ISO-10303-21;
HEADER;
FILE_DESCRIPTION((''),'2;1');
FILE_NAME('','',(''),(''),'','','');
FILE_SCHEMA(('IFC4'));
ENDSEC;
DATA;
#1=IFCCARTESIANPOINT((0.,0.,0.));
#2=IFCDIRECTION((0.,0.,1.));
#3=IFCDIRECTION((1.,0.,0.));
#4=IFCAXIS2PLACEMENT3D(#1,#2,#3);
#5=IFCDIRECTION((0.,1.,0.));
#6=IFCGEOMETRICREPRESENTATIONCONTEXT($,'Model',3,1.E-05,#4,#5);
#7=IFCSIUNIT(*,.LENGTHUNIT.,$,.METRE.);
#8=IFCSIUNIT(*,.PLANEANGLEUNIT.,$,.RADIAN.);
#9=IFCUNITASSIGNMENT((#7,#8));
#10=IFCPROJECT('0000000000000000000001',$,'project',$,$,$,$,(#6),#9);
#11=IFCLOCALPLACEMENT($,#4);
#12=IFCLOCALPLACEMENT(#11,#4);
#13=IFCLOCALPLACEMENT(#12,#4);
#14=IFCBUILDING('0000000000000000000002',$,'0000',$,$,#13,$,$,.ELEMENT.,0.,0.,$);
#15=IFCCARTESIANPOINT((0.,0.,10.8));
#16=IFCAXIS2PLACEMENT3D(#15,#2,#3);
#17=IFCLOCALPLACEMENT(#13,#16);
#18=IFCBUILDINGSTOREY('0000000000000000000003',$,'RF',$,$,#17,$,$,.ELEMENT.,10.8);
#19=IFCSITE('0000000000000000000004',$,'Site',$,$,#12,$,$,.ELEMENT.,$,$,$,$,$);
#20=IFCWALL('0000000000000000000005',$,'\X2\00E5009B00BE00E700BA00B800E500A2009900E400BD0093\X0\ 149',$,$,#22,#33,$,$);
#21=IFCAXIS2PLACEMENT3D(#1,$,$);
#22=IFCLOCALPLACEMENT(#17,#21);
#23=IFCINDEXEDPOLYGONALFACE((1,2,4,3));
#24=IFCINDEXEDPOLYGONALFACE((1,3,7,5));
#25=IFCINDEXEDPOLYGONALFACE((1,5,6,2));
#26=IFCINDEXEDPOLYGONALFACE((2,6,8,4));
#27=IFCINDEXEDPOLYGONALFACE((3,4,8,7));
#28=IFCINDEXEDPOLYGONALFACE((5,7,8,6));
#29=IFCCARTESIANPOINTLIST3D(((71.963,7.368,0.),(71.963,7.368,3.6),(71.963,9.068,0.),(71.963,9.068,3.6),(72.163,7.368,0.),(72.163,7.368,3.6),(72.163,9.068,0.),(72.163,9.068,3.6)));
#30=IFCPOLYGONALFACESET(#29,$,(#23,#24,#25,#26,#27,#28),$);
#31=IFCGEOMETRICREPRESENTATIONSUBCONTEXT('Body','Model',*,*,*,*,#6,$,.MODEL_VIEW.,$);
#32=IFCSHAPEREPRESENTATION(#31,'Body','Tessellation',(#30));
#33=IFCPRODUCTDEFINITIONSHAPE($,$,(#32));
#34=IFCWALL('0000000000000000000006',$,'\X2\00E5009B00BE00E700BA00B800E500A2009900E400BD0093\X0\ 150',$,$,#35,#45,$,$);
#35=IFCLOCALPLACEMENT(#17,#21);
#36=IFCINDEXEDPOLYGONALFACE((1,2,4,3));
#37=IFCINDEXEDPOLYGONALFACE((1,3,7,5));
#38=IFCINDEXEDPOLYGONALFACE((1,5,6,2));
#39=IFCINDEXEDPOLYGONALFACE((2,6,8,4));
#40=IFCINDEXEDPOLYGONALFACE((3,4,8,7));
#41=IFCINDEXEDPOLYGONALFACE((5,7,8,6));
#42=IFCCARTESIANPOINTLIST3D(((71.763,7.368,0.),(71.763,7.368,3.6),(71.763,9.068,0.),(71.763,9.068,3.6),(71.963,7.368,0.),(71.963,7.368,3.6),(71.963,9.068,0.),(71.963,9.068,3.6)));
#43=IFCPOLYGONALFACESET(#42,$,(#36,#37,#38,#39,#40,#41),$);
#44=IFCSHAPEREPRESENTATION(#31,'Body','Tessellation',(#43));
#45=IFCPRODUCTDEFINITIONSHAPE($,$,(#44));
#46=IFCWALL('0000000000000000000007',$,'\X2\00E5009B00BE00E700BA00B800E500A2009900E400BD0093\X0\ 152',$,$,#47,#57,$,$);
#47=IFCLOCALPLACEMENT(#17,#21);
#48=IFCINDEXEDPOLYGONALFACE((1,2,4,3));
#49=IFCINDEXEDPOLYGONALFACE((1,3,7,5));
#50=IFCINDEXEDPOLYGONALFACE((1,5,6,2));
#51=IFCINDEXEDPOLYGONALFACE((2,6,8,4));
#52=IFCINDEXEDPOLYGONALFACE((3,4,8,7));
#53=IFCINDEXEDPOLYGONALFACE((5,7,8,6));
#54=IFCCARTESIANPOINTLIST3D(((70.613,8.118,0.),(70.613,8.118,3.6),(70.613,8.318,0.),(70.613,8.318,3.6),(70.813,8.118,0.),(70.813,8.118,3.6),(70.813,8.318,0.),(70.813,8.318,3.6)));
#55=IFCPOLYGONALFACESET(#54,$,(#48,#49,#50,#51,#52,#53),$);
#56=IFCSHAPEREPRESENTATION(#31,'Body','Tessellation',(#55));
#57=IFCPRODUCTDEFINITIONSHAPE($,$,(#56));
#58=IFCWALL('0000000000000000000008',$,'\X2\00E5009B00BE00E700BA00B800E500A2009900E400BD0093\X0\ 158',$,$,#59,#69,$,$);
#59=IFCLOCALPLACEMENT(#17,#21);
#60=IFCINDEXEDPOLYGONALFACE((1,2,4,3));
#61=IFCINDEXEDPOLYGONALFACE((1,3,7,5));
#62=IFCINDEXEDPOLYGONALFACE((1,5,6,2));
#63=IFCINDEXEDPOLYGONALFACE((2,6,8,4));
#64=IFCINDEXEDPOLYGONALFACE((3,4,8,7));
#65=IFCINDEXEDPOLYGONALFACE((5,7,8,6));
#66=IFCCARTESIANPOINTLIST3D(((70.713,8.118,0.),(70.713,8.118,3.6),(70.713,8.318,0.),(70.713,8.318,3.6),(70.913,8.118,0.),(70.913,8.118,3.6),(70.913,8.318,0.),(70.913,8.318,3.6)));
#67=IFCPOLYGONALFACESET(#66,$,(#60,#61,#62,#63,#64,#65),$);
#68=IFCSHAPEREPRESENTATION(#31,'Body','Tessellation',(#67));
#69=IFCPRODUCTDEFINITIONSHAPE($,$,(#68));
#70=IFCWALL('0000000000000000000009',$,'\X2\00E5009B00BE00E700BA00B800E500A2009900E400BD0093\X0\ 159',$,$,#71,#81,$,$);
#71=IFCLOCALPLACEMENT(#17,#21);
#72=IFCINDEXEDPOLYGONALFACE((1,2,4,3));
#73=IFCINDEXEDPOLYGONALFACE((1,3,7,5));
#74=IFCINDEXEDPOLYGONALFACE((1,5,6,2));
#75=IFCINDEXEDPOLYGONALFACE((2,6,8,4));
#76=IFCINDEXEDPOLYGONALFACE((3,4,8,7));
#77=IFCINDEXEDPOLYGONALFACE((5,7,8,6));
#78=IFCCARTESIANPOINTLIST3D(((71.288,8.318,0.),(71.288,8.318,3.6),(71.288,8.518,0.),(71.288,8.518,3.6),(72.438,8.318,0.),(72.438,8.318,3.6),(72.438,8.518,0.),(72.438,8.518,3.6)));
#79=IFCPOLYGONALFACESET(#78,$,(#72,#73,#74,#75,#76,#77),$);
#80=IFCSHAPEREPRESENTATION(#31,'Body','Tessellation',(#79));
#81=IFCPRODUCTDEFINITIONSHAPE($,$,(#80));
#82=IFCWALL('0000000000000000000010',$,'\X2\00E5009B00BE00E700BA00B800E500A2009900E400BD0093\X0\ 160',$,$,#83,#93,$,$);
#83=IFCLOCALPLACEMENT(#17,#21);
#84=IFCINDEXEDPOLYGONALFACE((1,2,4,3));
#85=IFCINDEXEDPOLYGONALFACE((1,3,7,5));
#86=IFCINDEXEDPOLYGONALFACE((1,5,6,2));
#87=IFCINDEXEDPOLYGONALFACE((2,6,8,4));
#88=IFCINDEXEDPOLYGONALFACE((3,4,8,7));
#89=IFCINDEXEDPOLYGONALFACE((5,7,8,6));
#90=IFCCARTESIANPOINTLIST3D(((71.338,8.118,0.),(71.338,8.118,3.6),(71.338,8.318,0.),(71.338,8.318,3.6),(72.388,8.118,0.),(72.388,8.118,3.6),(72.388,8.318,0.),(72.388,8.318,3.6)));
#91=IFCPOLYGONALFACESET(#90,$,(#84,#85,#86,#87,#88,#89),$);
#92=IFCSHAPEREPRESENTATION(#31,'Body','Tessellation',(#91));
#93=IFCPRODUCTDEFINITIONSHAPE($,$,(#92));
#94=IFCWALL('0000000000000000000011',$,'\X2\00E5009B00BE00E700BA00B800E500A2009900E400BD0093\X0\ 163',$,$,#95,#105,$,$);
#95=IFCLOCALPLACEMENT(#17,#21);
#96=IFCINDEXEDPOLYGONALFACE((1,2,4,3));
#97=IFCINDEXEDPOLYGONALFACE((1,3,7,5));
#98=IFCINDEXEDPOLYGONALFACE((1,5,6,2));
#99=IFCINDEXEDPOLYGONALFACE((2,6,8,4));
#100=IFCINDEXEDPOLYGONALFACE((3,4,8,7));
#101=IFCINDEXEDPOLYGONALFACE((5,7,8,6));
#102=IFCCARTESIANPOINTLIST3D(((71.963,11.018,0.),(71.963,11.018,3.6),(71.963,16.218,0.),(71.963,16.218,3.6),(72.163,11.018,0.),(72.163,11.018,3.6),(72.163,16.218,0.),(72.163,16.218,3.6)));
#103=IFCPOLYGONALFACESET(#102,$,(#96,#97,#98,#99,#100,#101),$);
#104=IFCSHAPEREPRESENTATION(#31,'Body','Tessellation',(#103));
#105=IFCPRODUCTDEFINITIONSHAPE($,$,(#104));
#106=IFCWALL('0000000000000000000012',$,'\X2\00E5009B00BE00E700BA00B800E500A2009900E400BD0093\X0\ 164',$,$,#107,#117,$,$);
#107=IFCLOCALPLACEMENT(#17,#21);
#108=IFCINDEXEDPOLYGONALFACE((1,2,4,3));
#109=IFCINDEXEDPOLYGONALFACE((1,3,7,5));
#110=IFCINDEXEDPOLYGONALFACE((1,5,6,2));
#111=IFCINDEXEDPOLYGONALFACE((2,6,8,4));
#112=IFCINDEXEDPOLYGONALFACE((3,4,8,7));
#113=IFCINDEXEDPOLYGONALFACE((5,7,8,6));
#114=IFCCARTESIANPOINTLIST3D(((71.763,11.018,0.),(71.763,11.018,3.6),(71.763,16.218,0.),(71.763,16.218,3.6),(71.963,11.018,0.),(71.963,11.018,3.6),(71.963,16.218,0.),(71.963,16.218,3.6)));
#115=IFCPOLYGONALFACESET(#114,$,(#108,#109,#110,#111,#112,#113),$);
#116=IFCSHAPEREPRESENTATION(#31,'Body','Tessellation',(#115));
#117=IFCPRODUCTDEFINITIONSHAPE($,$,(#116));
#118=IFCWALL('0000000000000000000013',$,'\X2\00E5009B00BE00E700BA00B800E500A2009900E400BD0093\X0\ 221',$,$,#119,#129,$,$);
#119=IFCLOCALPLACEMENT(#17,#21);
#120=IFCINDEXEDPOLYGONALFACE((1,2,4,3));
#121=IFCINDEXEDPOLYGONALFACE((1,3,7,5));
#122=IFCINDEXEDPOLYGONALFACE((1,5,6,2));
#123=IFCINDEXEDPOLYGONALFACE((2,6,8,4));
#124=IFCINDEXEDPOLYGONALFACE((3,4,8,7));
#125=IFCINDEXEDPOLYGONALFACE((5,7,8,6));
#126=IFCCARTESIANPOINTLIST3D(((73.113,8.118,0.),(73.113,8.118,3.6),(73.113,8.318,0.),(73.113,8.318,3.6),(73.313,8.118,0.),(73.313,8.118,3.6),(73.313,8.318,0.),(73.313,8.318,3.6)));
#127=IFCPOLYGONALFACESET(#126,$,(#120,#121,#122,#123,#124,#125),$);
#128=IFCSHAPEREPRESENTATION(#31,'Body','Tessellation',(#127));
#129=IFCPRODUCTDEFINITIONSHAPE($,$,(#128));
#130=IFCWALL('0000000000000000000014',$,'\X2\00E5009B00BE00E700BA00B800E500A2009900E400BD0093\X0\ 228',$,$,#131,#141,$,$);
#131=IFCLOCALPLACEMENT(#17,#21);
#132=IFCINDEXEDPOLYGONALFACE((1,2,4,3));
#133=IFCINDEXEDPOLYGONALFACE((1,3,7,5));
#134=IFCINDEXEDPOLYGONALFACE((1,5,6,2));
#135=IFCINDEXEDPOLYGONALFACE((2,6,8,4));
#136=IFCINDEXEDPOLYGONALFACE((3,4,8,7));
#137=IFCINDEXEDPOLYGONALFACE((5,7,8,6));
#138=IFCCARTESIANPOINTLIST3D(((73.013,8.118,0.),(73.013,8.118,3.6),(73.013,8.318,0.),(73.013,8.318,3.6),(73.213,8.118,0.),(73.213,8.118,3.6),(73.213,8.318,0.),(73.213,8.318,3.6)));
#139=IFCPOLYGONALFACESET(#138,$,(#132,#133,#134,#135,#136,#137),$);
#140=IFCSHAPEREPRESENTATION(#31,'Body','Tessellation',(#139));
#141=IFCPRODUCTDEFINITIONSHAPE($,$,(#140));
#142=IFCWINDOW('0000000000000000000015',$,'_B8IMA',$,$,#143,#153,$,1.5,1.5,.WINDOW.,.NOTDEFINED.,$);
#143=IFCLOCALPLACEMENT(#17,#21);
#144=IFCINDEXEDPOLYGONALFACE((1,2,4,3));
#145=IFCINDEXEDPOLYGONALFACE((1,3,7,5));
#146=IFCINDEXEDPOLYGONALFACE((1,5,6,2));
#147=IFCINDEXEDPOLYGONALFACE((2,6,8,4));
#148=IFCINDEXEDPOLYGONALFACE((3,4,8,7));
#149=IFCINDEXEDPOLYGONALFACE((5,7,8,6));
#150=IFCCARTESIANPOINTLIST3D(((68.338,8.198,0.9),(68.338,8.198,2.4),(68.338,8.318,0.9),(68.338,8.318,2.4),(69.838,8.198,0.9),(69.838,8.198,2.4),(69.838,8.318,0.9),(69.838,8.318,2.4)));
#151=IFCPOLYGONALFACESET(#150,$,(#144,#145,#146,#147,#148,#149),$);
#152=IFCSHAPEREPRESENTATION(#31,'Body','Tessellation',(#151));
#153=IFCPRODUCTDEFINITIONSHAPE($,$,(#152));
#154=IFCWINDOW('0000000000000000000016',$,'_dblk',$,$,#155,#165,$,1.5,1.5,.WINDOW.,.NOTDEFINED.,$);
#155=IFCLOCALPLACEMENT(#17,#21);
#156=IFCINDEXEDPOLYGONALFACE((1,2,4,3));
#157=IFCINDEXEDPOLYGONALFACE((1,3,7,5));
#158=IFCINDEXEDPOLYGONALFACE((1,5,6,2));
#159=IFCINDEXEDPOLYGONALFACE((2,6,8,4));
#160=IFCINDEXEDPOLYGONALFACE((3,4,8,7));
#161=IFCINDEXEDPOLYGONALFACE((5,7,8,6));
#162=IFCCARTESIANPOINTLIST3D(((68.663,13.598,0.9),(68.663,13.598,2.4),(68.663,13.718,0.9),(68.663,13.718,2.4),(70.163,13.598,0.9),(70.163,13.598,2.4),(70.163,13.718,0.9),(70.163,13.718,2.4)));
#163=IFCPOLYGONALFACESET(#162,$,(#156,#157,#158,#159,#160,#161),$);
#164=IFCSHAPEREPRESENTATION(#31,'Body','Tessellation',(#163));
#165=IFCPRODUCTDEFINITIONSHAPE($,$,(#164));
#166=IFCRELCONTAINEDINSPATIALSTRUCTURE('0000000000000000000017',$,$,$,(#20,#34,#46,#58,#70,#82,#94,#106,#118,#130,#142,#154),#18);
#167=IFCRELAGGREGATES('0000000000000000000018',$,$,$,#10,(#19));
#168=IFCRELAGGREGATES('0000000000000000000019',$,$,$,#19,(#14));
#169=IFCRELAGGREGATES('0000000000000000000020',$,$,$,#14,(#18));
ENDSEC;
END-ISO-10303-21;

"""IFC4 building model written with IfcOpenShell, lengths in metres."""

from ifc_helpers import new_model, si_unit, direction, frame, frame_2d, origin_with_axes, place, context, subcontext, project, spatial, rectangle, extrude, element, save


model = new_model("IFC4")

# Units and contexts
model_context = context("Model", 3, precision=1e-05, world=origin_with_axes(), true_north=direction((0.0, 1.0, 0.0)))
body_context = subcontext(model_context, "Body", "Model", "MODEL_VIEW")
ifc_project = project(units=[si_unit("LENGTHUNIT", "METRE"), si_unit("PLANEANGLEUNIT", "RADIAN")], contexts=[model_context])

# Site, building, storey
placement = place(None, origin_with_axes())
site_placement = place(placement, origin_with_axes())
site = spatial("IfcSite", under=ifc_project, at=site_placement, Name="Site", CompositionType="ELEMENT")
building_placement = place(site_placement, origin_with_axes())
building = spatial("IfcBuilding", under=site, at=building_placement, Name="0000", CompositionType="ELEMENT", ElevationOfRefHeight=0.0, ElevationOfTerrain=0.0)
storey_placement = place(building_placement, frame((0.0, 0.0, 10.8), z_axis=(0.0, 0.0, 1.0), x_axis=(1.0, 0.0, 0.0)))
storey = spatial("IfcBuildingStorey", under=building, at=storey_placement, Name="RF", CompositionType="ELEMENT", Elevation=10.8)

# Walls
for number, where, z_axis, x_axis, name in (
    (1, (72.063, 8.218, 0.0), (0.0, 0.0, 1.0), (0.0, -1.0, 0.0), "å\u009b¾çº¸å¢\u0099ä½\u0093 149"),
    (2, (71.863, 8.218, 0.0), (0.0, 0.0, 1.0), (0.0, -1.0, 0.0), "å\u009b¾çº¸å¢\u0099ä½\u0093 150"),
):
    element("IfcWall", number, at=place(storey_placement, frame(where, z_axis=z_axis, x_axis=x_axis)), inside=storey, Name=name, context=body_context, shape_type="SweptSolid", body=[
        extrude(rectangle(XDim=1.7, YDim=0.2, at=frame_2d((0.0, 0.0), x_axis=(1.0, 0.0, 0.0))), frame((0.0, 0.0, 0.0), z_axis=(0.0, 0.0, 1.0)), (0.0, 0.0, 1.0), 3.6),
    ])
for number, where, z_axis, x_axis, name in (
    (3, (70.713, 8.218, 0.0), (0.0, 0.0, 1.0), (0.0, 1.0, 0.0), "å\u009b¾çº¸å¢\u0099ä½\u0093 152"),
    (4, (70.813, 8.218, 0.0), (0.0, 0.0, 1.0), (0.0, -1.0, 0.0), "å\u009b¾çº¸å¢\u0099ä½\u0093 158"),
):
    element("IfcWall", number, at=place(storey_placement, frame(where, z_axis=z_axis, x_axis=x_axis)), inside=storey, Name=name, context=body_context, shape_type="SweptSolid", body=[
        extrude(rectangle(XDim=0.2, YDim=0.2, at=frame_2d((0.0, 0.0), x_axis=(1.0, 0.0, 0.0))), frame((0.0, 0.0, 0.0), z_axis=(0.0, 0.0, 1.0)), (0.0, 0.0, 1.0), 3.6),
    ])
wall_1_placement = place(storey_placement, frame((71.863, 8.418, 0.0), z_axis=(0.0, 0.0, 1.0), x_axis=(-1.0, 0.0, 0.0)))
element("IfcWall", 5, at=wall_1_placement, inside=storey, Name="å\u009b¾çº¸å¢\u0099ä½\u0093 159", context=body_context, shape_type="SweptSolid", body=[
    extrude(rectangle(XDim=1.15, YDim=0.2, at=frame_2d((0.0, 0.0), x_axis=(1.0, 0.0, 0.0))), frame((0.0, 0.0, 0.0), z_axis=(0.0, 0.0, 1.0)), (0.0, 0.0, 1.0), 3.6),
])
wall_2_placement = place(storey_placement, frame((71.863, 8.218, 0.0), z_axis=(0.0, 0.0, 1.0), x_axis=(-1.0, 0.0, 0.0)))
element("IfcWall", 6, at=wall_2_placement, inside=storey, Name="å\u009b¾çº¸å¢\u0099ä½\u0093 160", context=body_context, shape_type="SweptSolid", body=[
    extrude(rectangle(XDim=1.05, YDim=0.2, at=frame_2d((0.0, 0.0), x_axis=(1.0, 0.0, 0.0))), frame((0.0, 0.0, 0.0), z_axis=(0.0, 0.0, 1.0)), (0.0, 0.0, 1.0), 3.6),
])
for number, where, z_axis, x_axis, name in (
    (7, (72.063, 13.618, 0.0), (0.0, 0.0, 1.0), (0.0, -1.0, 0.0), "å\u009b¾çº¸å¢\u0099ä½\u0093 163"),
    (8, (71.863, 13.618, 0.0), (0.0, 0.0, 1.0), (0.0, -1.0, 0.0), "å\u009b¾çº¸å¢\u0099ä½\u0093 164"),
):
    element("IfcWall", number, at=place(storey_placement, frame(where, z_axis=z_axis, x_axis=x_axis)), inside=storey, Name=name, context=body_context, shape_type="SweptSolid", body=[
        extrude(rectangle(XDim=5.2, YDim=0.2, at=frame_2d((0.0, 0.0), x_axis=(1.0, 0.0, 0.0))), frame((0.0, 0.0, 0.0), z_axis=(0.0, 0.0, 1.0)), (0.0, 0.0, 1.0), 3.6),
    ])
for number, where, z_axis, x_axis, name in (
    (9, (73.213, 8.218, 0.0), (0.0, 0.0, 1.0), (0.0, 1.0, 0.0), "å\u009b¾çº¸å¢\u0099ä½\u0093 221"),
    (10, (73.113, 8.218, 0.0), (0.0, 0.0, 1.0), (0.0, -1.0, 0.0), "å\u009b¾çº¸å¢\u0099ä½\u0093 228"),
):
    element("IfcWall", number, at=place(storey_placement, frame(where, z_axis=z_axis, x_axis=x_axis)), inside=storey, Name=name, context=body_context, shape_type="SweptSolid", body=[
        extrude(rectangle(XDim=0.2, YDim=0.2, at=frame_2d((0.0, 0.0), x_axis=(1.0, 0.0, 0.0))), frame((0.0, 0.0, 0.0), z_axis=(0.0, 0.0, 1.0)), (0.0, 0.0, 1.0), 3.6),
    ])

# Windows
for number, where, z_axis, x_axis, name in (
    (11, (69.088, 8.258, 0.9), (0.0, 0.0, 1.0), (1.0, 0.0, 0.0), "_B8IMA"),
    (12, (69.413, 13.658, 0.9), (0.0, 0.0, 1.0), (1.0, 0.0, 0.0), "_dblk"),
):
    element("IfcWindow", number, at=place(storey_placement, frame(where, z_axis=z_axis, x_axis=x_axis)), inside=storey, Name=name, OverallHeight=1.5, OverallWidth=1.5, PartitioningType="NOTDEFINED", PredefinedType="WINDOW", context=body_context, shape_type="SweptSolid", body=[
        extrude(rectangle(XDim=1.5, YDim=0.12, at=frame_2d((0.0, 0.0), x_axis=(1.0, 0.0, 0.0))), frame((0.0, 0.0, 0.0), z_axis=(0.0, 0.0, 1.0)), (0.0, 0.0, 1.0), 1.5),
    ])

save(model, "model.ifc")
